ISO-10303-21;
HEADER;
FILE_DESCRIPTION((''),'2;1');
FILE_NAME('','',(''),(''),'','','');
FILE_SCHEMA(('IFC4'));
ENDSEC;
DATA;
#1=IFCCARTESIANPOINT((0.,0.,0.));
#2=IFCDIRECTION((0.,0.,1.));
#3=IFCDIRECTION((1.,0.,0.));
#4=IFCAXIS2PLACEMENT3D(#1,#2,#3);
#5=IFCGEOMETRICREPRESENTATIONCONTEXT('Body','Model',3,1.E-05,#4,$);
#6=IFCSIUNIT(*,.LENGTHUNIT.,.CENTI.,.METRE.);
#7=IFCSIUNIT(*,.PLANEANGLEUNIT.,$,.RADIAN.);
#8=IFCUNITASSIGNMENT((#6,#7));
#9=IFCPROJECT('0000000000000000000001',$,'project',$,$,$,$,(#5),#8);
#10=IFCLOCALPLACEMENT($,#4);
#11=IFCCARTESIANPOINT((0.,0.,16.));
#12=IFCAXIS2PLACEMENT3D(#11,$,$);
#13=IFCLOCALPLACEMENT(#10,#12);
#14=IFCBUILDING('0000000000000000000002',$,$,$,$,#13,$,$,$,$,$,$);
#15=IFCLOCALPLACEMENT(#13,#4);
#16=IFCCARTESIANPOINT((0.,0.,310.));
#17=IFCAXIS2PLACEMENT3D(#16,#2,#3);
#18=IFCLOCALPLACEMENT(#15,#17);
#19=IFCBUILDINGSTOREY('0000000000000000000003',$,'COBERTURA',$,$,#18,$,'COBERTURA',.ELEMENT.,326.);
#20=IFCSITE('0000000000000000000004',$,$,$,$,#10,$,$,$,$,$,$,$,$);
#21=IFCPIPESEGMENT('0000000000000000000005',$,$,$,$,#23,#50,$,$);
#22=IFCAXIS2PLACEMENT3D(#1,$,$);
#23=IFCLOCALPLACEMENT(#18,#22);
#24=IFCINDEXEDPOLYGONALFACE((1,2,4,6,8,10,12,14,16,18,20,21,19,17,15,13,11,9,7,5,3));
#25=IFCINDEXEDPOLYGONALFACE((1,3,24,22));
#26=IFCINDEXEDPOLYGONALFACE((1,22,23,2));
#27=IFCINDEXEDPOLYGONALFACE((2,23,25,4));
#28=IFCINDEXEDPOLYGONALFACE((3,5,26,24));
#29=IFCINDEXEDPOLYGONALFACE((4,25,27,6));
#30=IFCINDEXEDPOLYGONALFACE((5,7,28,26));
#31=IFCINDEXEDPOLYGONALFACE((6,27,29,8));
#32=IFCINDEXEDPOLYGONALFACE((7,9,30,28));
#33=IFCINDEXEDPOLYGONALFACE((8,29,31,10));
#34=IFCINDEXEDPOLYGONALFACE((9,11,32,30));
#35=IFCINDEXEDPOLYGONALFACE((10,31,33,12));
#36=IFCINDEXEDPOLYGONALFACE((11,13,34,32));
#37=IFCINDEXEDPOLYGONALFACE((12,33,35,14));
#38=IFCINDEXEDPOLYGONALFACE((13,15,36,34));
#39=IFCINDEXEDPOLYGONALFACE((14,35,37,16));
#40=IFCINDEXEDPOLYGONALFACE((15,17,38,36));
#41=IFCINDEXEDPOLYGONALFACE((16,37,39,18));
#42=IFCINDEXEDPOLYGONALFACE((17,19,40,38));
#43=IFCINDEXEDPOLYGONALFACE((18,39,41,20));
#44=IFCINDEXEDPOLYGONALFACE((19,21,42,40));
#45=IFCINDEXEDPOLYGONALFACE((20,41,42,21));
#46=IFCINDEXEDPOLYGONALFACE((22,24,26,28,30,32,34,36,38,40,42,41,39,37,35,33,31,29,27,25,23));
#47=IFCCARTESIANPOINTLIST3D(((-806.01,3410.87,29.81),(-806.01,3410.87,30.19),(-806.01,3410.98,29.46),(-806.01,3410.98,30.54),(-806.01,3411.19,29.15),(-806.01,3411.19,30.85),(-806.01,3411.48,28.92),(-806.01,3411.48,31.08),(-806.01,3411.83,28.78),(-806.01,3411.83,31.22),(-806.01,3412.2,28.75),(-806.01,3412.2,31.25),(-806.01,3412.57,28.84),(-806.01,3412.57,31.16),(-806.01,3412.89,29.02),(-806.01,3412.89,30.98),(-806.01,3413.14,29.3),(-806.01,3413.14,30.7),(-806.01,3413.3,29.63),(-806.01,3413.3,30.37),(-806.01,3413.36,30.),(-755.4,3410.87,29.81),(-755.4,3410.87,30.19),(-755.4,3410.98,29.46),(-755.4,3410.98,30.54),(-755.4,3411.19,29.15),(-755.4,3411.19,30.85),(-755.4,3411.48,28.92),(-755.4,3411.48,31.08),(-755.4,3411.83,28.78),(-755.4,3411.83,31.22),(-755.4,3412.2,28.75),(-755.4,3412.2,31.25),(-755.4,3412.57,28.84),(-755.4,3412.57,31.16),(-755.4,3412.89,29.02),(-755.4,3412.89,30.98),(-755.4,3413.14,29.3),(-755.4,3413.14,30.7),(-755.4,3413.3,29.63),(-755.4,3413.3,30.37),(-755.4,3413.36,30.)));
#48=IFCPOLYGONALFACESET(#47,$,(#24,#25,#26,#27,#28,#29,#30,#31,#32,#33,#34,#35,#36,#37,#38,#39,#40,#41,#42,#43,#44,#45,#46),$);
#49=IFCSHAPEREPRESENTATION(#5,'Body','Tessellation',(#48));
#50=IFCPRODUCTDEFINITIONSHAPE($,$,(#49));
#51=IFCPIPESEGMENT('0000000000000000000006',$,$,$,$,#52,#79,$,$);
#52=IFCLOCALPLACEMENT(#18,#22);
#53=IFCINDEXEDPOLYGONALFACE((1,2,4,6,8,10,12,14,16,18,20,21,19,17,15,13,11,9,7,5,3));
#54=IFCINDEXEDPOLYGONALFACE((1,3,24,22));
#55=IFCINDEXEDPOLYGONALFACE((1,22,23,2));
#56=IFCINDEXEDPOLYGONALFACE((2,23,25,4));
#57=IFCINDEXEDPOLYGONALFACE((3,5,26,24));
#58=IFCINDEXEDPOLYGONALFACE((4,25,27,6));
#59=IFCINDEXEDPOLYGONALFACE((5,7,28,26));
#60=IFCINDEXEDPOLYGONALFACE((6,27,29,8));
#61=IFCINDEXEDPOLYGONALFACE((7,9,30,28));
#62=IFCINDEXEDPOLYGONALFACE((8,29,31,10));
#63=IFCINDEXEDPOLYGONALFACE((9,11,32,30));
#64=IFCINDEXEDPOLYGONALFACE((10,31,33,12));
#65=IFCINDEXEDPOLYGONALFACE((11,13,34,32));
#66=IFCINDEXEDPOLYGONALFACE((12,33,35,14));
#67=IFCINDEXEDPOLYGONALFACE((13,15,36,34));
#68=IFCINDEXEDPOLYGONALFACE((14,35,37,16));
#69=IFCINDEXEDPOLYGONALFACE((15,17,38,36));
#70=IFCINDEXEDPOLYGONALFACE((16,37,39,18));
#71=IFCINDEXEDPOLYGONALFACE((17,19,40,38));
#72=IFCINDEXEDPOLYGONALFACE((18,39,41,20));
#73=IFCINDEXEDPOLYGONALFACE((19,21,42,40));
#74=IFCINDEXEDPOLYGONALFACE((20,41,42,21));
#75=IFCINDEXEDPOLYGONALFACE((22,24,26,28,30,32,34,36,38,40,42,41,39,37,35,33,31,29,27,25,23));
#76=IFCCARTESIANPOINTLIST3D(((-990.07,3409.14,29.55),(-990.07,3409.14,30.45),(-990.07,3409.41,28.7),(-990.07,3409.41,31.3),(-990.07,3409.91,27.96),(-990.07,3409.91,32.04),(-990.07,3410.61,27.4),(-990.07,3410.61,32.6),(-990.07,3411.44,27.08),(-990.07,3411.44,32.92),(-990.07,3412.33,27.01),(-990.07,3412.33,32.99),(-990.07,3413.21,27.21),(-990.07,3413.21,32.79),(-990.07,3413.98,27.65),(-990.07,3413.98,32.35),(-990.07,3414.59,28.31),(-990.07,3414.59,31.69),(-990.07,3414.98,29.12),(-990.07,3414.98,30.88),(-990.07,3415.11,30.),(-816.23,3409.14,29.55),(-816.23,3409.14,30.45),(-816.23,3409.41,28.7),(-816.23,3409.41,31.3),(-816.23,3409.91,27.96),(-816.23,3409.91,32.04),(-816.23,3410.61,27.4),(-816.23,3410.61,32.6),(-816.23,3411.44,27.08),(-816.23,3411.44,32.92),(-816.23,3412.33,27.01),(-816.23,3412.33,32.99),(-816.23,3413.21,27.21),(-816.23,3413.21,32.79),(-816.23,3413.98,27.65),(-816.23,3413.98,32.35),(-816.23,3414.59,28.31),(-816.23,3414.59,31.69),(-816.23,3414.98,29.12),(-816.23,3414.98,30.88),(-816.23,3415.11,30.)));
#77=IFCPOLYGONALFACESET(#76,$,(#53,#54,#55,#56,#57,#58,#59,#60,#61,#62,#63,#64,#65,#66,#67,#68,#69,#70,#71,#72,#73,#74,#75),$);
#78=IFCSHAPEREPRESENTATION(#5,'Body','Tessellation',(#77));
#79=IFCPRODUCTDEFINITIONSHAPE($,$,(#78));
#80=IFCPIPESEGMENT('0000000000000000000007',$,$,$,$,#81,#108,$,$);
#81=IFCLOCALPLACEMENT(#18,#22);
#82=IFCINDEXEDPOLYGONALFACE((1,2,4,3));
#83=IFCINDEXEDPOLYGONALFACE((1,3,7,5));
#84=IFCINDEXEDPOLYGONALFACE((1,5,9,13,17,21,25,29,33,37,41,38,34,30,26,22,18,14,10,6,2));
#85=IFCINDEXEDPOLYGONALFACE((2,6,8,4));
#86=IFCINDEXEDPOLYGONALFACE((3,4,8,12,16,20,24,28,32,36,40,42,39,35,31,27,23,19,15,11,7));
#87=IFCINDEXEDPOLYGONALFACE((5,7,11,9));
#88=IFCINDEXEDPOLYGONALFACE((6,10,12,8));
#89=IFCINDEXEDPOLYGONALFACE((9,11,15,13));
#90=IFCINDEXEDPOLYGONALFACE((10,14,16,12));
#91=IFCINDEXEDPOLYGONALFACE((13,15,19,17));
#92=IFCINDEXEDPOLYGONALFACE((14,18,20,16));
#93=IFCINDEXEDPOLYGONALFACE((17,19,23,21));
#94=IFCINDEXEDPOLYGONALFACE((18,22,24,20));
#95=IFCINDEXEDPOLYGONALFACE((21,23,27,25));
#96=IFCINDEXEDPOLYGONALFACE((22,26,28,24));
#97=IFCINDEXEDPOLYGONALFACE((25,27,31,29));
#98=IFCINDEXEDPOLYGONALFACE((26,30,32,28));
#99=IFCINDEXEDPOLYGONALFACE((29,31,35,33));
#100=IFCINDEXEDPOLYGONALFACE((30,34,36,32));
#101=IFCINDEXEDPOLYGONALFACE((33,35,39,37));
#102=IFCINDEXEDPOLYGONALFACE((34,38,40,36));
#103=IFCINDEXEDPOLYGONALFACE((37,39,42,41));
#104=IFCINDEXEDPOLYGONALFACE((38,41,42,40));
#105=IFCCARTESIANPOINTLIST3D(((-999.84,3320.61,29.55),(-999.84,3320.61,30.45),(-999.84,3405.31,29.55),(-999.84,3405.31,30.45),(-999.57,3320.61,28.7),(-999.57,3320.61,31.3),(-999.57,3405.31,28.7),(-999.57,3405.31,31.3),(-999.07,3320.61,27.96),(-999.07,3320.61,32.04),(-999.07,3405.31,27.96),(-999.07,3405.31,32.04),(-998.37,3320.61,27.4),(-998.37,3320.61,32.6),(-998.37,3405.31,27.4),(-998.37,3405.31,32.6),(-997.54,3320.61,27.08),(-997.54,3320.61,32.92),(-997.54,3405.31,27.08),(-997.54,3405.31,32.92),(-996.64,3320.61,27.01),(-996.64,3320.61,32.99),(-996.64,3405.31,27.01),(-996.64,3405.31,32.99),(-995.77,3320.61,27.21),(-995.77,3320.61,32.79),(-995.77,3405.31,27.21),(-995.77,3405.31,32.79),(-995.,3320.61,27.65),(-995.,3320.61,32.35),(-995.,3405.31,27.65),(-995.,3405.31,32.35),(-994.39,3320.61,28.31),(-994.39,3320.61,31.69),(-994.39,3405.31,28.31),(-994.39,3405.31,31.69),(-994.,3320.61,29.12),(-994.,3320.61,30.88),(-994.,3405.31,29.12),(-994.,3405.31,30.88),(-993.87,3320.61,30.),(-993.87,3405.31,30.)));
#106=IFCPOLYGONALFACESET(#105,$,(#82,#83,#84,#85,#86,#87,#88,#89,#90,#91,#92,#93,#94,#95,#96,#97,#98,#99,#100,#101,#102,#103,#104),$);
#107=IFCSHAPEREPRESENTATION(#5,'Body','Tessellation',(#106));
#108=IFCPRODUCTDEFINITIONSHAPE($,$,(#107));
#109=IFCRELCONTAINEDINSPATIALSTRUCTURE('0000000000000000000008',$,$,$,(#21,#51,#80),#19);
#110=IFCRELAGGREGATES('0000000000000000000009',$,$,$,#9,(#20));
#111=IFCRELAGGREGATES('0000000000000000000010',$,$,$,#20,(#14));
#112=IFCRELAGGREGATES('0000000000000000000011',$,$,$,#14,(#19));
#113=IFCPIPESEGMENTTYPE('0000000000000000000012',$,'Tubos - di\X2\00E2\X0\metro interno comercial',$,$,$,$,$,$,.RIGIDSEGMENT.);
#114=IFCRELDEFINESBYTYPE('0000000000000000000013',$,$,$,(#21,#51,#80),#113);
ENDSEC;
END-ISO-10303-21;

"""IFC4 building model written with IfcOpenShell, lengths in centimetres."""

from ifc_helpers import new_model, si_unit, frame, origin_with_axes, origin_2d_with_axis, place, context, project, spatial, circle, extrude, type_object, element, save


model = new_model("IFC4")

# Units and contexts
model_context = context("Model", 3, precision=1e-05, world=origin_with_axes(), identifier="Body")
ifc_project = project(units=[si_unit("LENGTHUNIT", "METRE", prefix="CENTI"), si_unit("PLANEANGLEUNIT", "RADIAN")], contexts=[model_context])

# Site, building, storey
site_placement = place(None, origin_with_axes())
site = spatial("IfcSite", under=ifc_project, at=site_placement)
building_placement = place(site_placement, frame((0.0, 0.0, 16.0)))
building = spatial("IfcBuilding", under=site, at=building_placement)
placement = place(building_placement, origin_with_axes())
storey_placement = place(placement, frame((0.0, 0.0, 310.0), z_axis=(0.0, 0.0, 1.0), x_axis=(1.0, 0.0, 0.0)))
storey = spatial("IfcBuildingStorey", under=building, at=storey_placement, Name="COBERTURA", LongName="COBERTURA", CompositionType="ELEMENT", Elevation=326.0)

# Pipe segments
pipe_segment_type = type_object("IfcPipeSegmentType", Name="Tubos - diâmetro interno comercial", PredefinedType="RIGIDSEGMENT")
pipe_segment_1_placement = place(storey_placement, frame((-780.7, 3412.11, 31.25), z_axis=(0.0, 0.0, 1.0), x_axis=(1.0, 0.0, 0.0)))
element("IfcPipeSegment", 1, at=pipe_segment_1_placement, inside=storey, type_object=pipe_segment_type, context=model_context, shape_type="SolidModel", body=[
    extrude(circle(Radius=1.25, at=origin_2d_with_axis()), frame((-25.3, 0.0, -1.25), z_axis=(1.0, 0.0, 0.0), x_axis=(0.0, 1.0, 0.0)), (0.0, 0.0, 1.0), 50.61),
])
pipe_segment_2_placement = place(storey_placement, frame((-903.15, 3412.11, 33.0), z_axis=(0.0, 0.0, 1.0), x_axis=(1.0, 0.0, 0.0)))
element("IfcPipeSegment", 2, at=pipe_segment_2_placement, inside=storey, type_object=pipe_segment_type, context=model_context, shape_type="SolidModel", body=[
    extrude(circle(Radius=3.0, at=origin_2d_with_axis()), frame((-86.92, 0.0, -3.0), z_axis=(1.0, 0.0, 0.0), x_axis=(0.0, 1.0, 0.0)), (0.0, 0.0, 1.0), 173.84),
])
pipe_segment_3_placement = place(storey_placement, frame((-996.87, 3362.96, 33.0), z_axis=(0.0, 0.0, 1.0), x_axis=(1.0, 0.0, 0.0)))
element("IfcPipeSegment", 3, at=pipe_segment_3_placement, inside=storey, type_object=pipe_segment_type, context=model_context, shape_type="SolidModel", body=[
    extrude(circle(Radius=3.0, at=origin_2d_with_axis()), frame((0.0, 42.35, -3.0), z_axis=(0.0, -1.0, 0.0), x_axis=(1.0, 0.0, 0.0)), (0.0, 0.0, 1.0), 84.7),
])

save(model, "model.ifc")
